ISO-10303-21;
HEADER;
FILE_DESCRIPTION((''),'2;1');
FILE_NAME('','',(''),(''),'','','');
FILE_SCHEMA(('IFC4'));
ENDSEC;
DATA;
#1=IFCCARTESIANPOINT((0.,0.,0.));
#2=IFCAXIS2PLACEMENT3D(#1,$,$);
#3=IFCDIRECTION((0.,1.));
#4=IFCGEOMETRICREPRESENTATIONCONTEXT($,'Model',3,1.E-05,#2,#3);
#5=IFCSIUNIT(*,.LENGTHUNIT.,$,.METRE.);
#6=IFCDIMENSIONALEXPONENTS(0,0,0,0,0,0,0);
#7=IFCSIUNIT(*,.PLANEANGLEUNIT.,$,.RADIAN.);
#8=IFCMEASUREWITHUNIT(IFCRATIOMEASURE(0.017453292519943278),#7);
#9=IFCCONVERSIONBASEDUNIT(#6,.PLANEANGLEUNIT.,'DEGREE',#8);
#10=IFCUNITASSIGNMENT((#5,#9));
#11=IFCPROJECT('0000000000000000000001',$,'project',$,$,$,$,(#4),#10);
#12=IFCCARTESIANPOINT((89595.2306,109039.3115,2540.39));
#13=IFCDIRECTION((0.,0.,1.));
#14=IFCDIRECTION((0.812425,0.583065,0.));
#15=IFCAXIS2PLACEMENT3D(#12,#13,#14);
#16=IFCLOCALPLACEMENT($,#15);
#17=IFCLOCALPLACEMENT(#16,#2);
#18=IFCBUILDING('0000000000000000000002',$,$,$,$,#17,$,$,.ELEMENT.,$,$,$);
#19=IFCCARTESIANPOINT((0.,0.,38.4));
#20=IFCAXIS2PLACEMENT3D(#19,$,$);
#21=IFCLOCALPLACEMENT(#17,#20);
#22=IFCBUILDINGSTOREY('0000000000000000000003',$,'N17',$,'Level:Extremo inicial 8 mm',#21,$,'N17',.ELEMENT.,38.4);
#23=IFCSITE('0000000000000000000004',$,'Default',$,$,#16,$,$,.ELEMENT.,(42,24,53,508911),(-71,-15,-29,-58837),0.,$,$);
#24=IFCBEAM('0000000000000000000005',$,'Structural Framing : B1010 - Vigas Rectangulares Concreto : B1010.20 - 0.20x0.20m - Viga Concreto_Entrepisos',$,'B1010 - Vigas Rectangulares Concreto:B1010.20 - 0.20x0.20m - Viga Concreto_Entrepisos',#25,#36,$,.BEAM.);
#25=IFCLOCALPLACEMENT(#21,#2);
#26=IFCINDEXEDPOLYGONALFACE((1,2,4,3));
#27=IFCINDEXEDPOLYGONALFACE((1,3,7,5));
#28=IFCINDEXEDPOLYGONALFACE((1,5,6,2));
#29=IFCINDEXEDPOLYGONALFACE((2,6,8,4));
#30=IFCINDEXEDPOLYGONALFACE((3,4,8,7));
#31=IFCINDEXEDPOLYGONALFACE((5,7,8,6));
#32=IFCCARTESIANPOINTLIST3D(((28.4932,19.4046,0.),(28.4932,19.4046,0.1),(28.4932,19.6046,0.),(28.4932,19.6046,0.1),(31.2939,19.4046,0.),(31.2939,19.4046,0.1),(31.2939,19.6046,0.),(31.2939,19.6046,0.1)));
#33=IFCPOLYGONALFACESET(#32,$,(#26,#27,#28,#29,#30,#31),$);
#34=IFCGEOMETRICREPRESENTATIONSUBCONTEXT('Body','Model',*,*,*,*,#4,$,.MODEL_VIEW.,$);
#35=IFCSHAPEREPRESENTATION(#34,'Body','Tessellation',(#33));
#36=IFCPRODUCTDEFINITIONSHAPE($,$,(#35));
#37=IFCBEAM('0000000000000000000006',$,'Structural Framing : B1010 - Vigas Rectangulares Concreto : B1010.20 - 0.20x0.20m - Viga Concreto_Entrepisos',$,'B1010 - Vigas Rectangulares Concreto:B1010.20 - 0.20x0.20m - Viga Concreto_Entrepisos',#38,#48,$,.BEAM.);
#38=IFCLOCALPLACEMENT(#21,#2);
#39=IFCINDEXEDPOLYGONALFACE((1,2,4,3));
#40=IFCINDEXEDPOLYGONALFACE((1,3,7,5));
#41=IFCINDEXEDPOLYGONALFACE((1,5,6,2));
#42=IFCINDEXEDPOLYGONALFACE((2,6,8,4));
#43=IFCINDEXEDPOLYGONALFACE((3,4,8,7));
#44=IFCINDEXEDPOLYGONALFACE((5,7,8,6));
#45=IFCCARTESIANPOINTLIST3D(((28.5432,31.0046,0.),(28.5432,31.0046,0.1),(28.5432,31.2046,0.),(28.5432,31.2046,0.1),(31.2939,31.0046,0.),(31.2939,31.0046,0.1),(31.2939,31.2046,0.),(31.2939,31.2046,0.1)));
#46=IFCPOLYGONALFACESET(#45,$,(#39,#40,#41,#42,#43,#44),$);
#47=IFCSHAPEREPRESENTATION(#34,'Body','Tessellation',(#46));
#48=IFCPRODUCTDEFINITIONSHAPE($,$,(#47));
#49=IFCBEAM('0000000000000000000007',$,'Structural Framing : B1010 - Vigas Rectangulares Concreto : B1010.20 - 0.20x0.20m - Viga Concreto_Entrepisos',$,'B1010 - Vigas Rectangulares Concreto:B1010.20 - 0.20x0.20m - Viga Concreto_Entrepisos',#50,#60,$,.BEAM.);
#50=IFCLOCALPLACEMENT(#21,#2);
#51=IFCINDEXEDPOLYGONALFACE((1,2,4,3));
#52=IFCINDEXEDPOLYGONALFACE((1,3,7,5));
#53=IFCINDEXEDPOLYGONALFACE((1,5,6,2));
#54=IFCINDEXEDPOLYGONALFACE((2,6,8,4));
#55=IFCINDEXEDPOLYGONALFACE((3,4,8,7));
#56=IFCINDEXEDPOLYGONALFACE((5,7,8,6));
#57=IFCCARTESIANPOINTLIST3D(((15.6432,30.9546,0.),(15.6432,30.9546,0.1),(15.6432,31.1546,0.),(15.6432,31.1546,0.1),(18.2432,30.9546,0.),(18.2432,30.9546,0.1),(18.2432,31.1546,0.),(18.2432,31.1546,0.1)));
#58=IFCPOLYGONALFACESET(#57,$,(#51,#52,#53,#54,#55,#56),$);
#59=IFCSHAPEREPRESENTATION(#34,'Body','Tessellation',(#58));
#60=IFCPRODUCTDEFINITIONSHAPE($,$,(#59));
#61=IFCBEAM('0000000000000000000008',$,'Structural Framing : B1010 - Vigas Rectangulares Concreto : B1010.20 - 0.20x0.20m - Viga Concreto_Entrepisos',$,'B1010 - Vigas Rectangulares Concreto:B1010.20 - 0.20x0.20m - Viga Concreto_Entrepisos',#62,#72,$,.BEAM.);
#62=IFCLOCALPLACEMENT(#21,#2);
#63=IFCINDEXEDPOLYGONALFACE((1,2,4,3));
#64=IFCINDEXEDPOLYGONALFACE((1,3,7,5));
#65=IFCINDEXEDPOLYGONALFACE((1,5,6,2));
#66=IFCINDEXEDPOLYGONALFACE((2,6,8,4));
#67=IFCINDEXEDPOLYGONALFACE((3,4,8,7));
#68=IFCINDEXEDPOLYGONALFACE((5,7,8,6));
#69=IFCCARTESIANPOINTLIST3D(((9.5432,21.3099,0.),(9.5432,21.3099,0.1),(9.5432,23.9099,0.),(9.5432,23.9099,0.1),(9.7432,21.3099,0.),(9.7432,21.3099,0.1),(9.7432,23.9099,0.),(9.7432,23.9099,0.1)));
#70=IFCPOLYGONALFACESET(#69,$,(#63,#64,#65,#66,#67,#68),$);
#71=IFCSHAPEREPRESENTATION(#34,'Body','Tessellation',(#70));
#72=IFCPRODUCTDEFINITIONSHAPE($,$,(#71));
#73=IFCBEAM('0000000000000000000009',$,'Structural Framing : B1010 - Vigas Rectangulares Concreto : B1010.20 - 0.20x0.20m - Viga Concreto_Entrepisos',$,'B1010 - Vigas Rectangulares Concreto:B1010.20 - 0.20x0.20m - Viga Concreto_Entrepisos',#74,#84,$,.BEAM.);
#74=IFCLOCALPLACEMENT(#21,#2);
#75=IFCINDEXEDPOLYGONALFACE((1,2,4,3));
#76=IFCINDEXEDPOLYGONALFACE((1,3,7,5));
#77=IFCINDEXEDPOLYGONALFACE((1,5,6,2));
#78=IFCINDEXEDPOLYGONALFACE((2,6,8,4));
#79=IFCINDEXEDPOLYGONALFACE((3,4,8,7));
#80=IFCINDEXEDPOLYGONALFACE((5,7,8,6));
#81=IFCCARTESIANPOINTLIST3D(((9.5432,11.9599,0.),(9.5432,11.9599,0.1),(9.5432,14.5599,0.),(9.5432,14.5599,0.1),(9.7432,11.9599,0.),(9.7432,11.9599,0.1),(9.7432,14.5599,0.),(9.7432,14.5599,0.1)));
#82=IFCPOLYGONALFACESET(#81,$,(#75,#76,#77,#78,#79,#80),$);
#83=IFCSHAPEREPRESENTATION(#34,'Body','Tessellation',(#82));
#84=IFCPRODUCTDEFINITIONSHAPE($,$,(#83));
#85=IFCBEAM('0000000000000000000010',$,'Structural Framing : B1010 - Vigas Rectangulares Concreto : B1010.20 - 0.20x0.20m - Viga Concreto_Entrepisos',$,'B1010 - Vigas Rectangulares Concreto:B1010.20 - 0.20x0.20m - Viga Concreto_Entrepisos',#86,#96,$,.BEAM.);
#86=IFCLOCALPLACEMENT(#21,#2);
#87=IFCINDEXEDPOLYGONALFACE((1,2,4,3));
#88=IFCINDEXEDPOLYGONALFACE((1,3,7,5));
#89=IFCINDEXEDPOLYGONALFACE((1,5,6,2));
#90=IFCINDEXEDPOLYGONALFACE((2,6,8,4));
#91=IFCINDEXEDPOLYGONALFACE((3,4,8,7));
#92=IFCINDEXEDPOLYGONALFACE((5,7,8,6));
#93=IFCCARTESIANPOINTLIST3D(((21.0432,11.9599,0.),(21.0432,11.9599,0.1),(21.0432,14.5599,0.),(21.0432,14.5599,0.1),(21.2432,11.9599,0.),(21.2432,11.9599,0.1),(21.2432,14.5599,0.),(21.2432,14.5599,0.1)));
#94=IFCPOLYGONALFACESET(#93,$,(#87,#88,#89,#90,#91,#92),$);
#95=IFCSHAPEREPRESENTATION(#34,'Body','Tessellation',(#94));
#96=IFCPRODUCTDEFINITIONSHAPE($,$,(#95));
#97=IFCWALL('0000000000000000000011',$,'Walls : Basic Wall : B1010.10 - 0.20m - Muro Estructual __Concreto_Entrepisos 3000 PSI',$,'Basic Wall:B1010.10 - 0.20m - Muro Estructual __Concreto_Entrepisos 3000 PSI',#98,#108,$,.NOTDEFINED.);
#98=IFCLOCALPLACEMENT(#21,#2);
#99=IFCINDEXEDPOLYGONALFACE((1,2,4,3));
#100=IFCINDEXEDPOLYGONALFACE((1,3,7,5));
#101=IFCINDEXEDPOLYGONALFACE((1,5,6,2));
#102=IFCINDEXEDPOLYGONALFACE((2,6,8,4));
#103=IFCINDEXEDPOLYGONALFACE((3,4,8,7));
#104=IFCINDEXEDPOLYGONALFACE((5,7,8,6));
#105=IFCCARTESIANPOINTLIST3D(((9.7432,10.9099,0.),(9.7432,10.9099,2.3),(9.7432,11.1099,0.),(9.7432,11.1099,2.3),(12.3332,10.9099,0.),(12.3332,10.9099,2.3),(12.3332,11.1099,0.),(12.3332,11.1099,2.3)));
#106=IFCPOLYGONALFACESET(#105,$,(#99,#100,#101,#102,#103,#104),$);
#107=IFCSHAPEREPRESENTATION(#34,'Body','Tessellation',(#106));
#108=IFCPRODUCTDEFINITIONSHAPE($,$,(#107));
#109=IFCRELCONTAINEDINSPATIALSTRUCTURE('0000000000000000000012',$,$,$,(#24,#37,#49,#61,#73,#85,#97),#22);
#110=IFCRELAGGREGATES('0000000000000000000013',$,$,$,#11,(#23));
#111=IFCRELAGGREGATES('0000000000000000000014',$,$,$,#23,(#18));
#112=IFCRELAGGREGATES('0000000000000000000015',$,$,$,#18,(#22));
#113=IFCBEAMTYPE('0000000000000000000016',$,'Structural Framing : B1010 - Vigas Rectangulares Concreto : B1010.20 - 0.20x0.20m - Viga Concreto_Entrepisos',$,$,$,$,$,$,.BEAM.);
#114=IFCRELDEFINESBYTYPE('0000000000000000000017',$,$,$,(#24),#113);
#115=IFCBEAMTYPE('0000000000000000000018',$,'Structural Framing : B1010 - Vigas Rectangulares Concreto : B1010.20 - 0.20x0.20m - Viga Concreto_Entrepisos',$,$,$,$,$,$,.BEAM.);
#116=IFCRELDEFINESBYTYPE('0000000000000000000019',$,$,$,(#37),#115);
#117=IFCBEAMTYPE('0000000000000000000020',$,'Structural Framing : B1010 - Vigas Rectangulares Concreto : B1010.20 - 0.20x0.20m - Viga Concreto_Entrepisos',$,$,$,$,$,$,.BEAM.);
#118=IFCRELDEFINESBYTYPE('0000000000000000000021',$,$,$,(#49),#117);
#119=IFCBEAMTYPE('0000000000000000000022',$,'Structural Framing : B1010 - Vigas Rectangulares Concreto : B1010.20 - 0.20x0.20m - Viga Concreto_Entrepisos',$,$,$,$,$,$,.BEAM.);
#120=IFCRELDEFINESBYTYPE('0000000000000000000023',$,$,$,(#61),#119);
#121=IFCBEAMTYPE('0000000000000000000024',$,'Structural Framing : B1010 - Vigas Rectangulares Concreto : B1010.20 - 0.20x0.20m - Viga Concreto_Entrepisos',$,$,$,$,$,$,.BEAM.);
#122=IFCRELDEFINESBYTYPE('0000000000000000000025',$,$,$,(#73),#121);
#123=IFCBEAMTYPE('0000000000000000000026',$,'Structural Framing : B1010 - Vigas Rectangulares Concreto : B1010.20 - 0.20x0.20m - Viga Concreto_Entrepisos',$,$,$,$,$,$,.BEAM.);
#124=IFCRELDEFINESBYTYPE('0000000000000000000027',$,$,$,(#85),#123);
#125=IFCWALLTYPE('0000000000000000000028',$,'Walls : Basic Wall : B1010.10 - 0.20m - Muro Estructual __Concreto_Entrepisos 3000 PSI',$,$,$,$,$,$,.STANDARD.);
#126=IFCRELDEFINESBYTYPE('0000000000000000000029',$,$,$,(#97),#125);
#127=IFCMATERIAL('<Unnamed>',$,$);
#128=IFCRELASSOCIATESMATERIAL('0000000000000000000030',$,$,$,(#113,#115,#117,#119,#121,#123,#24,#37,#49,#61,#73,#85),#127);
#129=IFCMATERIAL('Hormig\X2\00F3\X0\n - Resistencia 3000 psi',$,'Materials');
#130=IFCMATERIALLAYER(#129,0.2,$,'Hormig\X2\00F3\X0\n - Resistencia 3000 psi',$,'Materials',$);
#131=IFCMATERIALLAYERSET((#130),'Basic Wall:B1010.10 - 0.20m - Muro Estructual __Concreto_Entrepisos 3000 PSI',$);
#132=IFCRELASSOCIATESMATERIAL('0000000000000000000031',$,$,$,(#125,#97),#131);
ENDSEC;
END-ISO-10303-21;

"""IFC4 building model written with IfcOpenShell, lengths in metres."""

from ifc_helpers import new_model, entity, si_unit, converted_unit, direction, frame, frame_2d, origin, place, context, subcontext, project, spatial, polyline, segment, composite_curve, rectangle, outline, extrude, source, transform, mapped, material, layer, layer_set, layer_usage, material_profile, profile_set, profile_usage, type_object, type_shapes, element, save


model = new_model("IFC4")

# Units and contexts
model_context = context("Model", 3, precision=1e-05, world=origin(), true_north=direction((0.0, 1.0)))
body_context = subcontext(model_context, "Body", "Model", "MODEL_VIEW")
ifc_project = project(units=[si_unit("LENGTHUNIT", "METRE"), converted_unit("PLANEANGLEUNIT", "DEGREE", entity("IfcRatioMeasure", 0.017453292519943278), si_unit("PLANEANGLEUNIT", "RADIAN"), dimensions=[0, 0, 0, 0, 0, 0, 0])], contexts=[model_context])

# Site, building, storey
site_placement = place(None, frame((89595.2306, 109039.3115, 2540.39), z_axis=(0.0, 0.0, 1.0), x_axis=(0.812425, 0.583065, 0.0)))
site = spatial("IfcSite", under=ifc_project, at=site_placement, Name="Default", CompositionType="ELEMENT", RefLatitude=(42, 24, 53, 508911), RefLongitude=(-71, -15, -29, -58837), RefElevation=0.0)
building_placement = place(site_placement, origin())
building = spatial("IfcBuilding", under=site, at=building_placement, CompositionType="ELEMENT")
storey_placement = place(building_placement, frame((0.0, 0.0, 38.4)))
storey = spatial("IfcBuildingStorey", under=building, at=storey_placement, Name="N17", ObjectType="Level:Extremo inicial 8 mm", LongName="N17", CompositionType="ELEMENT", Elevation=38.4)

# Beams
ifc_material_1 = material(Name="<Unnamed>")
ifc_material_profile_1 = material_profile(ifc_material_1, outline(composite_curve([segment(polyline([(-0.1, 0.0, 0.0), (-0.1, 0.1, 0.0)]), True, "CONTINUOUS"), segment(polyline([(-0.1, 0.1, 0.0), (0.1, 0.1, 0.0)]), True, "CONTINUOUS"), segment(polyline([(0.1, 0.1, 0.0), (0.1, 0.0, 0.0)]), True, "CONTINUOUS"), segment(polyline([(0.1, 0.0, 0.0), (-0.1, 0.0, 0.0)]), True, "CONTINUOUS")], self_intersect=False), kind="CURVE"), Name="B1010.20 - 0.20x0.20m - Viga Concreto_Entrepisos")
ifc_material_profile_2 = material_profile(ifc_material_1, outline(composite_curve([segment(polyline([(-1.4004, -0.1, 0.1), (-1.4004, 0.1, 0.1)]), True, "CONTINUOUS"), segment(polyline([(-1.4004, 0.1, 0.1), (-1.4004, 0.1, -0.1)]), True, "CONTINUOUS"), segment(polyline([(-1.4004, 0.1, -0.1), (-1.4004, -0.1, -0.1)]), True, "CONTINUOUS"), segment(polyline([(-1.4004, -0.1, -0.1), (-1.4004, -0.1, 0.1)]), True, "CONTINUOUS")], self_intersect=False), kind="CURVE"), Name="B1010.20 - 0.20x0.20m - Viga Concreto_Entrepisos")
ifc_profile_set_1 = profile_set([ifc_material_profile_1, ifc_material_profile_2], Name="B1010.20 - 0.20x0.20m - Viga Concreto_Entrepisos")
ifc_profile_usage_1 = profile_usage(ifc_profile_set_1, cardinal=8)
beam_type_1 = type_object("IfcBeamType", Name="Structural Framing : B1010 - Vigas Rectangulares Concreto : B1010.20 - 0.20x0.20m - Viga Concreto_Entrepisos", PredefinedType="BEAM", material=ifc_profile_set_1)
shared_shape_1 = source(origin(), body_context, "Body", "SweptSolid", [
    extrude(rectangle(XDim=0.1, YDim=0.2, at=frame_2d((0.0, 0.0), x_axis=(1.0, 0.0))), frame((31.2939, 19.5046, 38.45), z_axis=(-1.0, 0.0, 0.0), x_axis=(0.0, 0.0, -1.0)), (0.0, 0.0, 1.0), 2.8007),
])
type_shapes(beam_type_1, [shared_shape_1])
beam_1_placement = place(storey_placement, frame((0.0, 0.0, -38.4)))
element("IfcBeam", 1, at=beam_1_placement, inside=storey, type_object=beam_type_1, material=ifc_profile_usage_1, Name="Structural Framing : B1010 - Vigas Rectangulares Concreto : B1010.20 - 0.20x0.20m - Viga Concreto_Entrepisos", ObjectType="B1010 - Vigas Rectangulares Concreto:B1010.20 - 0.20x0.20m - Viga Concreto_Entrepisos", PredefinedType="BEAM", context=body_context, shape_type="MappedRepresentation", body=[
    mapped(shared_shape_1, transform((0.0, 0.0, 0.0), scale=1.0)),
])
ifc_profile_usage_2 = profile_usage(ifc_profile_set_1, cardinal=8)
beam_type_2 = type_object("IfcBeamType", Name="Structural Framing : B1010 - Vigas Rectangulares Concreto : B1010.20 - 0.20x0.20m - Viga Concreto_Entrepisos", PredefinedType="BEAM", material=ifc_profile_set_1)
shared_shape_2 = source(origin(), body_context, "Body", "SweptSolid", [
    extrude(rectangle(XDim=0.1, YDim=0.2, at=frame_2d((0.0, 0.0), x_axis=(1.0, 0.0))), frame((31.2939, 31.1046, 38.45), z_axis=(-1.0, 0.0, 0.0), x_axis=(0.0, 0.0, -1.0)), (0.0, 0.0, 1.0), 2.7507),
])
type_shapes(beam_type_2, [shared_shape_2])
beam_2_placement = place(storey_placement, frame((0.0, 0.0, -38.4)))
element("IfcBeam", 2, at=beam_2_placement, inside=storey, type_object=beam_type_2, material=ifc_profile_usage_2, Name="Structural Framing : B1010 - Vigas Rectangulares Concreto : B1010.20 - 0.20x0.20m - Viga Concreto_Entrepisos", ObjectType="B1010 - Vigas Rectangulares Concreto:B1010.20 - 0.20x0.20m - Viga Concreto_Entrepisos", PredefinedType="BEAM", context=body_context, shape_type="MappedRepresentation", body=[
    mapped(shared_shape_2, transform((0.0, 0.0, 0.0), scale=1.0)),
])
ifc_profile_usage_3 = profile_usage(ifc_profile_set_1, cardinal=8)
beam_type_3 = type_object("IfcBeamType", Name="Structural Framing : B1010 - Vigas Rectangulares Concreto : B1010.20 - 0.20x0.20m - Viga Concreto_Entrepisos", PredefinedType="BEAM", material=ifc_profile_set_1)
shared_shape_3 = source(origin(), body_context, "Body", "SweptSolid", [
    extrude(rectangle(XDim=0.1, YDim=0.2, at=frame_2d((0.0, 0.0), x_axis=(1.0, 0.0))), frame((18.2432, 31.0546, 38.45), z_axis=(-1.0, 0.0, 0.0), x_axis=(0.0, 0.0, -1.0)), (0.0, 0.0, 1.0), 2.6),
])
type_shapes(beam_type_3, [shared_shape_3])
beam_3_placement = place(storey_placement, frame((0.0, 0.0, -38.4)))
element("IfcBeam", 3, at=beam_3_placement, inside=storey, type_object=beam_type_3, material=ifc_profile_usage_3, Name="Structural Framing : B1010 - Vigas Rectangulares Concreto : B1010.20 - 0.20x0.20m - Viga Concreto_Entrepisos", ObjectType="B1010 - Vigas Rectangulares Concreto:B1010.20 - 0.20x0.20m - Viga Concreto_Entrepisos", PredefinedType="BEAM", context=body_context, shape_type="MappedRepresentation", body=[
    mapped(shared_shape_3, transform((0.0, 0.0, 0.0), scale=1.0)),
])
ifc_profile_usage_4 = profile_usage(ifc_profile_set_1, cardinal=8)
beam_type_4 = type_object("IfcBeamType", Name="Structural Framing : B1010 - Vigas Rectangulares Concreto : B1010.20 - 0.20x0.20m - Viga Concreto_Entrepisos", PredefinedType="BEAM", material=ifc_profile_set_1)
shared_shape_4 = source(origin(), body_context, "Body", "SweptSolid", [
    extrude(rectangle(XDim=0.1, YDim=0.2, at=frame_2d((0.0, 0.0), x_axis=(0.0, 1.0))), frame((9.6432, 21.3099, 38.45), z_axis=(0.0, 1.0, 0.0), x_axis=(-1.0, 0.0, 0.0)), (0.0, 0.0, 1.0), 2.6),
])
type_shapes(beam_type_4, [shared_shape_4])
beam_4_placement = place(storey_placement, frame((0.0, 0.0, -38.4)))
element("IfcBeam", 4, at=beam_4_placement, inside=storey, type_object=beam_type_4, material=ifc_profile_usage_4, Name="Structural Framing : B1010 - Vigas Rectangulares Concreto : B1010.20 - 0.20x0.20m - Viga Concreto_Entrepisos", ObjectType="B1010 - Vigas Rectangulares Concreto:B1010.20 - 0.20x0.20m - Viga Concreto_Entrepisos", PredefinedType="BEAM", context=body_context, shape_type="MappedRepresentation", body=[
    mapped(shared_shape_4, transform((0.0, 0.0, 0.0), scale=1.0)),
])
ifc_profile_usage_5 = profile_usage(ifc_profile_set_1, cardinal=8)
beam_type_5 = type_object("IfcBeamType", Name="Structural Framing : B1010 - Vigas Rectangulares Concreto : B1010.20 - 0.20x0.20m - Viga Concreto_Entrepisos", PredefinedType="BEAM", material=ifc_profile_set_1)
shared_shape_5 = source(origin(), body_context, "Body", "SweptSolid", [
    extrude(rectangle(XDim=0.1, YDim=0.2, at=frame_2d((0.0, 0.0), x_axis=(0.0, 1.0))), frame((9.6432, 11.9599, 38.45), z_axis=(0.0, 1.0, 0.0), x_axis=(-1.0, 0.0, 0.0)), (0.0, 0.0, 1.0), 2.6),
])
type_shapes(beam_type_5, [shared_shape_5])
beam_5_placement = place(storey_placement, frame((0.0, 0.0, -38.4)))
element("IfcBeam", 5, at=beam_5_placement, inside=storey, type_object=beam_type_5, material=ifc_profile_usage_5, Name="Structural Framing : B1010 - Vigas Rectangulares Concreto : B1010.20 - 0.20x0.20m - Viga Concreto_Entrepisos", ObjectType="B1010 - Vigas Rectangulares Concreto:B1010.20 - 0.20x0.20m - Viga Concreto_Entrepisos", PredefinedType="BEAM", context=body_context, shape_type="MappedRepresentation", body=[
    mapped(shared_shape_5, transform((0.0, 0.0, 0.0), scale=1.0)),
])
ifc_profile_usage_6 = profile_usage(ifc_profile_set_1, cardinal=8)
beam_type_6 = type_object("IfcBeamType", Name="Structural Framing : B1010 - Vigas Rectangulares Concreto : B1010.20 - 0.20x0.20m - Viga Concreto_Entrepisos", PredefinedType="BEAM", material=ifc_profile_set_1)
shared_shape_6 = source(origin(), body_context, "Body", "SweptSolid", [
    extrude(rectangle(XDim=0.1, YDim=0.2, at=frame_2d((0.0, 0.0), x_axis=(0.0, 1.0))), frame((21.1432, 11.9599, 38.45), z_axis=(0.0, 1.0, 0.0), x_axis=(-1.0, 0.0, 0.0)), (0.0, 0.0, 1.0), 2.6),
])
type_shapes(beam_type_6, [shared_shape_6])
beam_6_placement = place(storey_placement, frame((0.0, 0.0, -38.4)))
element("IfcBeam", 6, at=beam_6_placement, inside=storey, type_object=beam_type_6, material=ifc_profile_usage_6, Name="Structural Framing : B1010 - Vigas Rectangulares Concreto : B1010.20 - 0.20x0.20m - Viga Concreto_Entrepisos", ObjectType="B1010 - Vigas Rectangulares Concreto:B1010.20 - 0.20x0.20m - Viga Concreto_Entrepisos", PredefinedType="BEAM", context=body_context, shape_type="MappedRepresentation", body=[
    mapped(shared_shape_6, transform((0.0, 0.0, 0.0), scale=1.0)),
])

# Wall
ifc_material_2 = material(Name="Hormigón - Resistencia 3000 psi", Category="Materials")
ifc_layer_1 = layer(ifc_material_2, 0.2, Name="Hormigón - Resistencia 3000 psi", Category="Materials")
ifc_layer_set_1 = layer_set([ifc_layer_1], Name="Basic Wall:B1010.10 - 0.20m - Muro Estructual __Concreto_Entrepisos 3000 PSI")
ifc_layer_usage_1 = layer_usage(ifc_layer_set_1, "AXIS2", "POSITIVE", -0.1)
wall_type = type_object("IfcWallType", Name="Walls : Basic Wall : B1010.10 - 0.20m - Muro Estructual __Concreto_Entrepisos 3000 PSI", PredefinedType="STANDARD", material=ifc_layer_set_1)
wall_placement = place(storey_placement, frame((9.7432, 11.0099, 0.0)))
element("IfcWall", 7, at=wall_placement, inside=storey, type_object=wall_type, material=ifc_layer_usage_1, Name="Walls : Basic Wall : B1010.10 - 0.20m - Muro Estructual __Concreto_Entrepisos 3000 PSI", ObjectType="Basic Wall:B1010.10 - 0.20m - Muro Estructual __Concreto_Entrepisos 3000 PSI", PredefinedType="NOTDEFINED", context=body_context, shape_type="SweptSolid", body=[
    extrude(rectangle(XDim=2.59, YDim=0.2, at=frame_2d((1.295, 0.0), x_axis=(-1.0, 0.0))), origin(), (0.0, 0.0, 1.0), 2.3),
])

save(model, "model.ifc")
